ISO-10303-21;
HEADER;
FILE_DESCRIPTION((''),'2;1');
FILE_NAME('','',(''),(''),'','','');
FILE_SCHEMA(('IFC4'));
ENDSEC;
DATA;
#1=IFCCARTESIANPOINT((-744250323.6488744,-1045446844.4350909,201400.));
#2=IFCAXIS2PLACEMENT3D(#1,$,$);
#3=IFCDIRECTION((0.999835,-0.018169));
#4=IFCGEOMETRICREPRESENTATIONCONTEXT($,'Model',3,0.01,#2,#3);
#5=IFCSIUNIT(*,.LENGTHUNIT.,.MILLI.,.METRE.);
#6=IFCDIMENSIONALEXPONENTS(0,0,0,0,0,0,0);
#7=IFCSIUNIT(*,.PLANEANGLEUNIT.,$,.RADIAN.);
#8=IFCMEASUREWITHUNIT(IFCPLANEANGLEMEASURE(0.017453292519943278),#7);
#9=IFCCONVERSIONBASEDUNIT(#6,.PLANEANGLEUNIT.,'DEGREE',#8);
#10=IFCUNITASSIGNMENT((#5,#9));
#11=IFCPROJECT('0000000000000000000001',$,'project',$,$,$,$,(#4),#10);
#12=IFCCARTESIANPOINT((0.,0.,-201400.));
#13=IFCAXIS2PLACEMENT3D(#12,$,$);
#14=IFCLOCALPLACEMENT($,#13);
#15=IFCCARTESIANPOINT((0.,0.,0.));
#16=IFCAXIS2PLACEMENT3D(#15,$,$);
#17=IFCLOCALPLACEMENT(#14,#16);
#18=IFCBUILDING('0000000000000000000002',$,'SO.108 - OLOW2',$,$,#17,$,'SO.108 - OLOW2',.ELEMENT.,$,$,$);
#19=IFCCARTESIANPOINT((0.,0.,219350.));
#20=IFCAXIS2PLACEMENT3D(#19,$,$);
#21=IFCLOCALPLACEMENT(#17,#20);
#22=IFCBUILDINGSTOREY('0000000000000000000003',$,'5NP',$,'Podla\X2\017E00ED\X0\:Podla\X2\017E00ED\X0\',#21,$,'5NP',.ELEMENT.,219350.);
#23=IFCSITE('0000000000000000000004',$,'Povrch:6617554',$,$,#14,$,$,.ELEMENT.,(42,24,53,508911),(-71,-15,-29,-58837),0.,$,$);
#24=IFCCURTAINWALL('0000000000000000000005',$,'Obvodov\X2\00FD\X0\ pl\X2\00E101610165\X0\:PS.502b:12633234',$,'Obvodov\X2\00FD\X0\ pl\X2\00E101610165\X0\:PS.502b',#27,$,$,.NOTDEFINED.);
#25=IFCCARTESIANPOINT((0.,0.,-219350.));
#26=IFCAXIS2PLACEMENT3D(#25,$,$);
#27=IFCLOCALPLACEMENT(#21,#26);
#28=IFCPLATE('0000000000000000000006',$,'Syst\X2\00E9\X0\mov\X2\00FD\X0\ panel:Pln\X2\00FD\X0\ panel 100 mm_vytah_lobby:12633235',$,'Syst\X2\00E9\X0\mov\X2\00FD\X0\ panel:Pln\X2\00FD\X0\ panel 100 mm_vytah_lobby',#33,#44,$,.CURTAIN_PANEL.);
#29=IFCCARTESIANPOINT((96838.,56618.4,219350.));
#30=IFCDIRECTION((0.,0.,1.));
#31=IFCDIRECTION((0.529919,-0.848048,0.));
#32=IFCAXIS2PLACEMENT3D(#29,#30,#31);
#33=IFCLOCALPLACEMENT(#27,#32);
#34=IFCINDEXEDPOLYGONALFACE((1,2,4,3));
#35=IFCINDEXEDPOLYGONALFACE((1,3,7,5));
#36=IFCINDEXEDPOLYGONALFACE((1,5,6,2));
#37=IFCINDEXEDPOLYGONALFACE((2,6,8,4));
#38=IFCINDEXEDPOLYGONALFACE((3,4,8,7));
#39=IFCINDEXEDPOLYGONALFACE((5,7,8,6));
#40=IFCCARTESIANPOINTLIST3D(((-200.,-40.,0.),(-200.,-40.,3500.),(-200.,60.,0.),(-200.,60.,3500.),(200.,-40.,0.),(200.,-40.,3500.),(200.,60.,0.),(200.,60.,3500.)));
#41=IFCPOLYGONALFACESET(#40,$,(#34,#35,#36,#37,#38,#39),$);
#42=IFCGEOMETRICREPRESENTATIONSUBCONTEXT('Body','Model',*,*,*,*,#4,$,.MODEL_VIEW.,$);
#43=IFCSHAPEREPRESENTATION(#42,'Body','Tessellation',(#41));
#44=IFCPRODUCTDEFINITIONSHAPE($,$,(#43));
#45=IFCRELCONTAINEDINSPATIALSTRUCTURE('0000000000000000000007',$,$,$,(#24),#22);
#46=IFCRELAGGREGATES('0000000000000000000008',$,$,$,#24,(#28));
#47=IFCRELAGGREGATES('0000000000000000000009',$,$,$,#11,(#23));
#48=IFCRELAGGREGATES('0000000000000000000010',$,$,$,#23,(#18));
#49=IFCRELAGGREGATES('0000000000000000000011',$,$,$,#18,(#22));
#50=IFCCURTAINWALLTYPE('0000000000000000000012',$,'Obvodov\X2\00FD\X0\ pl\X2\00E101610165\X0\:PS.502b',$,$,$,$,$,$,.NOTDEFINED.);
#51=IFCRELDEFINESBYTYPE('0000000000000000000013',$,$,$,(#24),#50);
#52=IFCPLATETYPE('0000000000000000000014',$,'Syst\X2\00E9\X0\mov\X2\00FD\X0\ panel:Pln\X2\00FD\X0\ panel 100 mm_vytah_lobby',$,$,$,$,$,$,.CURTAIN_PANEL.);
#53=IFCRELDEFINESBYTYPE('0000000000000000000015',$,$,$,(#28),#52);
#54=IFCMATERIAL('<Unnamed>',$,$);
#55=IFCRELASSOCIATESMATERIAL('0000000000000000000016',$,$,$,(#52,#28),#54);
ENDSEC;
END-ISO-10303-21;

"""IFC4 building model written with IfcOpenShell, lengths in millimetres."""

from ifc_helpers import new_model, entity, si_unit, converted_unit, direction, frame, origin, place, context, subcontext, project, spatial, indexed_curve, outline, extrude, source, transform, mapped, material, type_object, type_shapes, element, aggregate, save


model = new_model("IFC4")

# Units and contexts
model_context = context("Model", 3, precision=0.01, world=frame((-744250323.6488744, -1045446844.4350909, 201400.0)), true_north=direction((0.999835, -0.018169)))
body_context = subcontext(model_context, "Body", "Model", "MODEL_VIEW")
ifc_project = project(units=[si_unit("LENGTHUNIT", "METRE", prefix="MILLI"), converted_unit("PLANEANGLEUNIT", "DEGREE", entity("IfcPlaneAngleMeasure", 0.017453292519943278), si_unit("PLANEANGLEUNIT", "RADIAN"), dimensions=[0, 0, 0, 0, 0, 0, 0])], contexts=[model_context])

# Site, building, storey
site_placement = place(None, frame((0.0, 0.0, -201400.0)))
site = spatial("IfcSite", under=ifc_project, at=site_placement, Name="Povrch:6617554", CompositionType="ELEMENT", RefLatitude=(42, 24, 53, 508911), RefLongitude=(-71, -15, -29, -58837), RefElevation=0.0)
building_placement = place(site_placement, origin())
building = spatial("IfcBuilding", under=site, at=building_placement, Name="SO.108 - OLOW2", LongName="SO.108 - OLOW2", CompositionType="ELEMENT")
storey_placement = place(building_placement, frame((0.0, 0.0, 219350.0)))
storey = spatial("IfcBuildingStorey", under=building, at=storey_placement, Name="5NP", ObjectType="Podlaží:Podlaží", LongName="5NP", CompositionType="ELEMENT", Elevation=219350.0)

# Shared definitions
ifc_material_1 = material(Name="<Unnamed>")

# Curtain wall
curtain_wall_type_1 = type_object("IfcCurtainWallType", Name="Obvodový plášť:PS.502b", PredefinedType="NOTDEFINED")
curtain_wall_1_placement = place(storey_placement, frame((0.0, 0.0, -219350.0)))
curtain_wall_1 = element("IfcCurtainWall", 1, at=curtain_wall_1_placement, inside=storey, type_object=curtain_wall_type_1, Name="Obvodový plášť:PS.502b:12633234", ObjectType="Obvodový plášť:PS.502b", PredefinedType="NOTDEFINED")

# Plate
plate_type_1 = type_object("IfcPlateType", Name="Systémový panel:Plný panel 100 mm_vytah_lobby", PredefinedType="CURTAIN_PANEL", material=ifc_material_1)
shared_shape_1 = source(origin(), body_context, "Body", "SweptSolid", [
    extrude(outline(indexed_curve([(-50.0, -200.0), (50.0, -200.0), (50.0, 200.0), (-50.0, 200.0), (-50.0, -200.0)], self_intersect=False)), frame((0.0, 10.0, 0.0), z_axis=(0.0, 0.0, 1.0), x_axis=(0.0, 1.0, 0.0)), (0.0, 0.0, 1.0), 3500.0),
])
type_shapes(plate_type_1, [shared_shape_1])
plate_1_placement = place(curtain_wall_1_placement, frame((96838.0, 56618.4, 219350.0), z_axis=(0.0, 0.0, 1.0), x_axis=(0.529919, -0.848048, 0.0)))
plate_1 = element("IfcPlate", 2, at=plate_1_placement, type_object=plate_type_1, material=ifc_material_1, Name="Systémový panel:Plný panel 100 mm_vytah_lobby:12633235", ObjectType="Systémový panel:Plný panel 100 mm_vytah_lobby", PredefinedType="CURTAIN_PANEL", context=body_context, shape_type="MappedRepresentation", body=[
    mapped(shared_shape_1, transform((0.0, 0.0, 0.0), scale=1.0)),
])
aggregate(curtain_wall_1, [plate_1])

save(model, "model.ifc")
